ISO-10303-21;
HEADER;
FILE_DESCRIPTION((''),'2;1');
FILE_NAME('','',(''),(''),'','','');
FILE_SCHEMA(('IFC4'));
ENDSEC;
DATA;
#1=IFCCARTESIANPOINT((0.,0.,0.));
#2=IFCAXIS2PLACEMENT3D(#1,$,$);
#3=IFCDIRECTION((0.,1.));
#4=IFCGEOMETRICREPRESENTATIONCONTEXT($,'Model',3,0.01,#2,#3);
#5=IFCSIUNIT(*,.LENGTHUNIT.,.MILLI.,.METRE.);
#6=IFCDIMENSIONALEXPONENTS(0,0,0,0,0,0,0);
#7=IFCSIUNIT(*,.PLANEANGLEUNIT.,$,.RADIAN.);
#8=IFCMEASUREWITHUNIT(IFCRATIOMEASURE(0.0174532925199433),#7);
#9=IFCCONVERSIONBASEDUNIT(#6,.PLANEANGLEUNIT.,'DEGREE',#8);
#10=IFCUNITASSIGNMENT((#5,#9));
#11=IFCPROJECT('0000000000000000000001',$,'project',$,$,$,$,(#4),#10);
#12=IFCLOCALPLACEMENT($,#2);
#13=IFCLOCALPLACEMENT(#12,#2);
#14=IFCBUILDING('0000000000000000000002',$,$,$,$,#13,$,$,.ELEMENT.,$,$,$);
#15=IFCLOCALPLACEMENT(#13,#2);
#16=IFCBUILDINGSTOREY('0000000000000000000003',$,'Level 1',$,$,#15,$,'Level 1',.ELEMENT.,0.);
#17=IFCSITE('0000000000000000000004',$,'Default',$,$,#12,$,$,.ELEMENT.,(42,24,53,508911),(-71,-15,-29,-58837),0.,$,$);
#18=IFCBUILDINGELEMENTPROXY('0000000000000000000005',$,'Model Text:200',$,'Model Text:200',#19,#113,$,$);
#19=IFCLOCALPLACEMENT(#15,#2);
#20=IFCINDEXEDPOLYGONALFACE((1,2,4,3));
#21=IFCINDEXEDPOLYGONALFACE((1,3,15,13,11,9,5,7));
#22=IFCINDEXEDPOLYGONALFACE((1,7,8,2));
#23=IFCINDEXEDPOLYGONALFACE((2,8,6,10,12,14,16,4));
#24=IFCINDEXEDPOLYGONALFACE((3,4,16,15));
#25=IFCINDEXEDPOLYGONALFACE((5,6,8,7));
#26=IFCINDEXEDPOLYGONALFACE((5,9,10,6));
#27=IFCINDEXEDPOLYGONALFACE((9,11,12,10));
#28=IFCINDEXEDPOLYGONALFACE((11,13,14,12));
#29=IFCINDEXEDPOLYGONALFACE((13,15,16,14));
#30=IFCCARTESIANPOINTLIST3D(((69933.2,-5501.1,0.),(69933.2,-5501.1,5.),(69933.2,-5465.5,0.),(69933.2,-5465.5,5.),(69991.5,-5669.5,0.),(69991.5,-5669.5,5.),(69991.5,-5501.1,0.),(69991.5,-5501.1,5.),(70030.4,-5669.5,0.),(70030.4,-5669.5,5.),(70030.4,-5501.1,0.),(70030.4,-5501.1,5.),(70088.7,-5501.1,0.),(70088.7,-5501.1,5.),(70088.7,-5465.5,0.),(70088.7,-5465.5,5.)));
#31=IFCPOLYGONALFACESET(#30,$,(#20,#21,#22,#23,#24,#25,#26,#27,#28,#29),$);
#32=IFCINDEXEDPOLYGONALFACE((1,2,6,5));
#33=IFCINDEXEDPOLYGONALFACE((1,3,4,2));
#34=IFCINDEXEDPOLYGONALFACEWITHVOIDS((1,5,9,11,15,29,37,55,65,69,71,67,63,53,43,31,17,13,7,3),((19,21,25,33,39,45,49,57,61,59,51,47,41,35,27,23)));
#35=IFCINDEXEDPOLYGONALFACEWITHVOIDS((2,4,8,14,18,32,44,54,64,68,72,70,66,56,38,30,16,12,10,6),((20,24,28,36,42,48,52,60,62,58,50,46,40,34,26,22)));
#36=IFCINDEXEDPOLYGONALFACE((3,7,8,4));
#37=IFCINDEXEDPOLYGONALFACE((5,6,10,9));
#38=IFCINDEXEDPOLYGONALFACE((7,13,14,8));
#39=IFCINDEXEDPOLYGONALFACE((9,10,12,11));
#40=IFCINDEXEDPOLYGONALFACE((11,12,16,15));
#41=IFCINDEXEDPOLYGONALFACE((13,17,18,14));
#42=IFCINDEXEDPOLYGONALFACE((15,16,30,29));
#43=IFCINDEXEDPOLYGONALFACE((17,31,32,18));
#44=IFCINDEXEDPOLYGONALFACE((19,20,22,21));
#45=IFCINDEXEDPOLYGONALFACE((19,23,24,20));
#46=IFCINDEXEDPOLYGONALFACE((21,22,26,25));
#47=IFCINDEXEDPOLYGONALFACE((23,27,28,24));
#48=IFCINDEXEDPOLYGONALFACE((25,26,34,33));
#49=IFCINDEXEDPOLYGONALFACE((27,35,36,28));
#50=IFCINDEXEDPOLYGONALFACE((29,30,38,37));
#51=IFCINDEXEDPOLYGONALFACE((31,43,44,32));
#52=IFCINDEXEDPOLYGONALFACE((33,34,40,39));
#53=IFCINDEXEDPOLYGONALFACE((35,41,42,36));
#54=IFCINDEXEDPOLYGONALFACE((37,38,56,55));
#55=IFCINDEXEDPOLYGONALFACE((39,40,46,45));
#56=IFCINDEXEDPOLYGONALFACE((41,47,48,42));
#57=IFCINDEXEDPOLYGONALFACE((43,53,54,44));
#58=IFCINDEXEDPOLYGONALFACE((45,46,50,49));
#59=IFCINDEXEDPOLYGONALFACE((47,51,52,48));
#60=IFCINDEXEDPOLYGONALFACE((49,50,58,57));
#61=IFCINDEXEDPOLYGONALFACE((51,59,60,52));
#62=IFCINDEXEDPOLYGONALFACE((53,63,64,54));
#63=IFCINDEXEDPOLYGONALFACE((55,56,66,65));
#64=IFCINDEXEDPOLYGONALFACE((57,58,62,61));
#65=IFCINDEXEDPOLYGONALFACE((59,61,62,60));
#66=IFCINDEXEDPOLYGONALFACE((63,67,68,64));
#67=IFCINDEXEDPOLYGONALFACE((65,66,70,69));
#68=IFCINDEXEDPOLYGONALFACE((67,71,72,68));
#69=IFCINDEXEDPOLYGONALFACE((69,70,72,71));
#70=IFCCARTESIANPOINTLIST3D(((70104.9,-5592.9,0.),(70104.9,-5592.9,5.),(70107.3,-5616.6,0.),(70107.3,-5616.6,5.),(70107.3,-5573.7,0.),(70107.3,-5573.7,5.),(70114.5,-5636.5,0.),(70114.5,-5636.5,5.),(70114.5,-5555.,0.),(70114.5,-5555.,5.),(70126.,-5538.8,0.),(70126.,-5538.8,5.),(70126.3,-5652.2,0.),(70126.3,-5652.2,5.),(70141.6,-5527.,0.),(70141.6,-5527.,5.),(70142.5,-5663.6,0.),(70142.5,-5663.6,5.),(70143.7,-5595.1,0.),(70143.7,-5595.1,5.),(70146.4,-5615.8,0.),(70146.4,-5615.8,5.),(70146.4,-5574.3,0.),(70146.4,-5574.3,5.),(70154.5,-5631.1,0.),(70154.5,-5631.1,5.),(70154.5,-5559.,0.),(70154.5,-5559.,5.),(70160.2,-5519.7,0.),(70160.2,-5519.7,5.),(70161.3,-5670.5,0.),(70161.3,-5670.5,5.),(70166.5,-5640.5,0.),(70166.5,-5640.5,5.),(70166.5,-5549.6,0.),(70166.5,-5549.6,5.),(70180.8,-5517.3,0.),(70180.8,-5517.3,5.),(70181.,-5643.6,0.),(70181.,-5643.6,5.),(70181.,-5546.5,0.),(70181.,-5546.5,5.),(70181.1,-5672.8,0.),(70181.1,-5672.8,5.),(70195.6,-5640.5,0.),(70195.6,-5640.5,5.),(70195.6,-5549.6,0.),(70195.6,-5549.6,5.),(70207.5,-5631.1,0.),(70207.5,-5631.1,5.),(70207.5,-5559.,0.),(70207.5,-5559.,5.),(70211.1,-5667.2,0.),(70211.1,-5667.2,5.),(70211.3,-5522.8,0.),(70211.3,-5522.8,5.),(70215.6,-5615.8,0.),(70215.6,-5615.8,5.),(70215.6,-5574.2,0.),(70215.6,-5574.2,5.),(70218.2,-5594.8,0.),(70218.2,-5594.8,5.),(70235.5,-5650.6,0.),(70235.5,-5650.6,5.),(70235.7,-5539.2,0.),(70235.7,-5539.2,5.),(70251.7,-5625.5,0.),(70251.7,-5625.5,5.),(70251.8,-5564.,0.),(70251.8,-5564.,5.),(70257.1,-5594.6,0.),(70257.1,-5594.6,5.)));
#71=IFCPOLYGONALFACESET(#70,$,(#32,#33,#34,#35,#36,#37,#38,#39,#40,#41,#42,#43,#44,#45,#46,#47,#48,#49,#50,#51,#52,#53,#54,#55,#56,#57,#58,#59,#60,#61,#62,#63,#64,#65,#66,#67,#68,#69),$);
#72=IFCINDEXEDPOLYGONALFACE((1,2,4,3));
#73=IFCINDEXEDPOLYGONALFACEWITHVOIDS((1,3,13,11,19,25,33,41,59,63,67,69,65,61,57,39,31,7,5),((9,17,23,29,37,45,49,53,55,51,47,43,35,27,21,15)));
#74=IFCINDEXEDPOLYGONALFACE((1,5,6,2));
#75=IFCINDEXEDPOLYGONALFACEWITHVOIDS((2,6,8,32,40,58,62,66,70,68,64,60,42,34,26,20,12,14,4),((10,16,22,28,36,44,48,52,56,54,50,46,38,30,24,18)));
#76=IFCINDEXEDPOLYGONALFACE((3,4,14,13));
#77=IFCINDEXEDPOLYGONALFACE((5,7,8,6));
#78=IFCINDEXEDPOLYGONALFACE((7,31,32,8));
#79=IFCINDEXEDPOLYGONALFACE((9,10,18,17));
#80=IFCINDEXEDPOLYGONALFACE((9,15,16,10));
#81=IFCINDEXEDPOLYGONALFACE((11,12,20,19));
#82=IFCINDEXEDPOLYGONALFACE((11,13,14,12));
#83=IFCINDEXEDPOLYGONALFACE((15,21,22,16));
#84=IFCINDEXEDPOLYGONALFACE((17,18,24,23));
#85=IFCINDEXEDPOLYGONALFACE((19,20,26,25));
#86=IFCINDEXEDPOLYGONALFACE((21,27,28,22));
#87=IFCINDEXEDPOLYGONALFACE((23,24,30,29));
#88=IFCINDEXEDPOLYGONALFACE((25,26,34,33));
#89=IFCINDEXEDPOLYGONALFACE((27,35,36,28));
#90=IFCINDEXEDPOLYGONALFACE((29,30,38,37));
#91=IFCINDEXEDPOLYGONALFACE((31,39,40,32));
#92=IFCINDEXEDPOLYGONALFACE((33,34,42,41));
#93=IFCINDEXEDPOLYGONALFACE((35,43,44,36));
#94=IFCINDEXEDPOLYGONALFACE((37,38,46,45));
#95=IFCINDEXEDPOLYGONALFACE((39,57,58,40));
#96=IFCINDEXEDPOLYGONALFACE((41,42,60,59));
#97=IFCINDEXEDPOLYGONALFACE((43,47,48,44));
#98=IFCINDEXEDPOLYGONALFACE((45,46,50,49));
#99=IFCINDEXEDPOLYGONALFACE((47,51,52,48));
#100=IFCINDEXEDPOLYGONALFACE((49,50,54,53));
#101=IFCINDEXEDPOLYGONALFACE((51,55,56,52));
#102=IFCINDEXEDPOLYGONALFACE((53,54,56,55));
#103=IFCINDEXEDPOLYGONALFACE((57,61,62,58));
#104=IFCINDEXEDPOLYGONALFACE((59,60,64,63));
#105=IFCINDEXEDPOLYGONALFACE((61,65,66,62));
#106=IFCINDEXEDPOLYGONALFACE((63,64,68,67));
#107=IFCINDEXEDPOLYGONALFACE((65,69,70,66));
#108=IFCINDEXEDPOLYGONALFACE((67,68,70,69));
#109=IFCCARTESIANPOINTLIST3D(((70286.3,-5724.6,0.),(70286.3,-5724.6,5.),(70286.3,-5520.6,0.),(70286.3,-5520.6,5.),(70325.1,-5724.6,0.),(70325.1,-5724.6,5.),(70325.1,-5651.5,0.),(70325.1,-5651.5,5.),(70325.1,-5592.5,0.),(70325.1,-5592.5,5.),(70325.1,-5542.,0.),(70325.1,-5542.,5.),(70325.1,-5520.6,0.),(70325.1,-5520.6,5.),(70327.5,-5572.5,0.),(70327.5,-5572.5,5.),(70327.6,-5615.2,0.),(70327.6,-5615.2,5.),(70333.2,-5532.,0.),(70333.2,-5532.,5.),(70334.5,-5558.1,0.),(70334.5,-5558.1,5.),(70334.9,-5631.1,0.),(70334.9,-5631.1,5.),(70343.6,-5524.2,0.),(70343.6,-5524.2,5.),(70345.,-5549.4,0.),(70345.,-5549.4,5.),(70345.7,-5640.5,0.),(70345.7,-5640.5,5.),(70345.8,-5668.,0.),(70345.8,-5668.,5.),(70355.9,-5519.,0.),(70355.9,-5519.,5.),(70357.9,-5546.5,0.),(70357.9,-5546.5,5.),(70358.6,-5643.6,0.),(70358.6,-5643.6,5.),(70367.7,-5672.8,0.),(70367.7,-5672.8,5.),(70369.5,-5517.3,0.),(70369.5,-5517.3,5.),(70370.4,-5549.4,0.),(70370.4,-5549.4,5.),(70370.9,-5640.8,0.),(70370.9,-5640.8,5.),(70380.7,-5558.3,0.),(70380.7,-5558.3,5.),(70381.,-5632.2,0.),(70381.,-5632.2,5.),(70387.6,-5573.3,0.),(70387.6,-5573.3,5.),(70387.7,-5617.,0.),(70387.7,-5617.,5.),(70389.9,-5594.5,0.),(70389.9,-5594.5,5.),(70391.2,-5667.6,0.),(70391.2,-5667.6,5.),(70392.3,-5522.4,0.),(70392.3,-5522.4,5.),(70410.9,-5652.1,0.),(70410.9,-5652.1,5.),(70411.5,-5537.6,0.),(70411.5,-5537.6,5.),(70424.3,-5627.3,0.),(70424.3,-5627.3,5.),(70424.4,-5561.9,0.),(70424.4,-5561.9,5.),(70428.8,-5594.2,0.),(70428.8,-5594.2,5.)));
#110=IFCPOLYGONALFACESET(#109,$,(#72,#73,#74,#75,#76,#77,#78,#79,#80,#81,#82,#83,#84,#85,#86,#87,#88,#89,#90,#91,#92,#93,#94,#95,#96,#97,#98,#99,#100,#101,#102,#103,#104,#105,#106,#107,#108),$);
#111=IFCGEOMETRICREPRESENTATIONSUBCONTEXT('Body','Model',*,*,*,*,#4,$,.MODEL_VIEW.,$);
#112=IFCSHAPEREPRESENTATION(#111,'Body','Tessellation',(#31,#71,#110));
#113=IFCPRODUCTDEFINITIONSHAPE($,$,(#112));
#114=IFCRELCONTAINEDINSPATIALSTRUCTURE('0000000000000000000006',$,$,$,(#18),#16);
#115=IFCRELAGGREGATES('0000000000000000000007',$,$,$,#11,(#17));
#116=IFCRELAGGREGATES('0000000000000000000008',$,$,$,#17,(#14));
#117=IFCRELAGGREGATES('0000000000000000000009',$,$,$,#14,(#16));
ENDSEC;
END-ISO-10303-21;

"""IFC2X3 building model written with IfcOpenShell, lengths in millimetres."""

from ifc_helpers import new_model, entity, si_unit, converted_unit, direction, frame, origin, place, context, subcontext, project, spatial, polyline, outline, extrude, element, save


model = new_model("IFC2X3")

# Units and contexts
model_context = context("Model", 3, precision=0.01, world=origin(), true_north=direction((0.0, 1.0)))
body_context = subcontext(model_context, "Body", "Model", "MODEL_VIEW")
ifc_project = project(units=[si_unit("LENGTHUNIT", "METRE", prefix="MILLI"), converted_unit("PLANEANGLEUNIT", "DEGREE", entity("IfcRatioMeasure", 0.0174532925199433), si_unit("PLANEANGLEUNIT", "RADIAN"), dimensions=[0, 0, 0, 0, 0, 0, 0])], contexts=[model_context])

# Site, building, storey
site_placement = place(None, origin())
site = spatial("IfcSite", under=ifc_project, at=site_placement, Name="Default", CompositionType="ELEMENT", RefLatitude=(42, 24, 53, 508911), RefLongitude=(-71, -15, -29, -58837), RefElevation=0.0)
building_placement = place(site_placement, origin())
building = spatial("IfcBuilding", under=site, at=building_placement, CompositionType="ELEMENT")
storey_placement = place(building_placement, origin())
storey = spatial("IfcBuildingStorey", under=building, at=storey_placement, Name="Level 1", LongName="Level 1", CompositionType="ELEMENT", Elevation=0.0)

# Building element proxy
proxy_1_placement = place(storey_placement, origin())
element("IfcBuildingElementProxy", 1, at=proxy_1_placement, inside=storey, Name="Model Text:200", ObjectType="Model Text:200", context=body_context, shape_type="SweptSolid", body=[
    extrude(outline(polyline([(-19.4, -135.2), (19.4, -135.2), (19.4, 33.2), (77.7, 33.2), (77.7, 68.8), (-77.7, 68.8), (-77.7, 33.2), (-19.4, 33.2), (-19.4, -135.2)])), frame((70010.9, -5534.3, 0.0)), (0.0, 0.0, 1.0), 5.0),
    extrude(outline(polyline([(-8.8, -65.7), (15.1, -65.7), (35.5, -60.5), (52.3, -50.4), (65.3, -35.4), (74.1, -17.3), (78.4, 2.1), (75.9, 32.5), (61.8, 58.5), (38.4, 77.1), (8.3, 85.6), (-22.7, 83.3), (-49.0, 69.9), (-67.8, 47.3), (-76.3, 17.5), (-76.0, -3.3), (-70.7, -22.5), (-60.5, -39.2), (-45.5, -52.3), (-27.7, -61.4), (-8.8, -65.7)]), holes=[polyline([(-2.7, -27.2), (-23.1, -22.5), (-37.5, -12.9), (-45.7, 0.0), (-47.3, 14.8), (-42.7, 28.9), (-32.2, 39.9), (-16.3, 46.3), (4.5, 46.9), (25.1, 42.1), (39.6, 32.6), (47.7, 19.7), (49.4, 5.0), (44.8, -9.2), (34.2, -20.2), (18.2, -26.7), (-2.7, -27.2)])]), frame((70171.1, -5595.0, 0.0), z_axis=(0.0, 0.0, 1.0), x_axis=(0.100608, -0.994926, 0.0)), (0.0, 0.0, 1.0), 5.0),
    extrude(outline(polyline([(-73.1, -75.4), (130.9, -75.4), (130.9, -36.6), (57.8, -36.6), (74.3, -15.9), (79.1, 6.0), (73.9, 29.5), (58.4, 49.2), (33.6, 62.6), (0.5, 67.1), (-31.8, 62.8), (-56.1, 49.8), (-71.3, 30.7), (-76.4, 7.8), (-74.7, -5.8), (-69.6, -18.1), (-61.7, -28.5), (-51.7, -36.6), (-73.1, -36.6), (-73.1, -75.4)]), holes=[polyline([(-1.2, -36.6), (-21.2, -34.2), (-35.6, -27.2), (-44.3, -16.7), (-47.2, -3.8), (-44.3, 8.7), (-35.4, 19.0), (-20.4, 25.9), (0.8, 28.2), (23.3, 26.0), (38.5, 19.3), (47.1, 9.2), (49.9, -3.1), (46.8, -16.0), (37.4, -26.8), (21.5, -34.1), (-1.2, -36.6)])]), frame((70361.7, -5593.7, 0.0), z_axis=(0.0, 0.0, 1.0), x_axis=(0.0, -1.0, 0.0)), (0.0, 0.0, 1.0), 5.0),
])

save(model, "model.ifc")
